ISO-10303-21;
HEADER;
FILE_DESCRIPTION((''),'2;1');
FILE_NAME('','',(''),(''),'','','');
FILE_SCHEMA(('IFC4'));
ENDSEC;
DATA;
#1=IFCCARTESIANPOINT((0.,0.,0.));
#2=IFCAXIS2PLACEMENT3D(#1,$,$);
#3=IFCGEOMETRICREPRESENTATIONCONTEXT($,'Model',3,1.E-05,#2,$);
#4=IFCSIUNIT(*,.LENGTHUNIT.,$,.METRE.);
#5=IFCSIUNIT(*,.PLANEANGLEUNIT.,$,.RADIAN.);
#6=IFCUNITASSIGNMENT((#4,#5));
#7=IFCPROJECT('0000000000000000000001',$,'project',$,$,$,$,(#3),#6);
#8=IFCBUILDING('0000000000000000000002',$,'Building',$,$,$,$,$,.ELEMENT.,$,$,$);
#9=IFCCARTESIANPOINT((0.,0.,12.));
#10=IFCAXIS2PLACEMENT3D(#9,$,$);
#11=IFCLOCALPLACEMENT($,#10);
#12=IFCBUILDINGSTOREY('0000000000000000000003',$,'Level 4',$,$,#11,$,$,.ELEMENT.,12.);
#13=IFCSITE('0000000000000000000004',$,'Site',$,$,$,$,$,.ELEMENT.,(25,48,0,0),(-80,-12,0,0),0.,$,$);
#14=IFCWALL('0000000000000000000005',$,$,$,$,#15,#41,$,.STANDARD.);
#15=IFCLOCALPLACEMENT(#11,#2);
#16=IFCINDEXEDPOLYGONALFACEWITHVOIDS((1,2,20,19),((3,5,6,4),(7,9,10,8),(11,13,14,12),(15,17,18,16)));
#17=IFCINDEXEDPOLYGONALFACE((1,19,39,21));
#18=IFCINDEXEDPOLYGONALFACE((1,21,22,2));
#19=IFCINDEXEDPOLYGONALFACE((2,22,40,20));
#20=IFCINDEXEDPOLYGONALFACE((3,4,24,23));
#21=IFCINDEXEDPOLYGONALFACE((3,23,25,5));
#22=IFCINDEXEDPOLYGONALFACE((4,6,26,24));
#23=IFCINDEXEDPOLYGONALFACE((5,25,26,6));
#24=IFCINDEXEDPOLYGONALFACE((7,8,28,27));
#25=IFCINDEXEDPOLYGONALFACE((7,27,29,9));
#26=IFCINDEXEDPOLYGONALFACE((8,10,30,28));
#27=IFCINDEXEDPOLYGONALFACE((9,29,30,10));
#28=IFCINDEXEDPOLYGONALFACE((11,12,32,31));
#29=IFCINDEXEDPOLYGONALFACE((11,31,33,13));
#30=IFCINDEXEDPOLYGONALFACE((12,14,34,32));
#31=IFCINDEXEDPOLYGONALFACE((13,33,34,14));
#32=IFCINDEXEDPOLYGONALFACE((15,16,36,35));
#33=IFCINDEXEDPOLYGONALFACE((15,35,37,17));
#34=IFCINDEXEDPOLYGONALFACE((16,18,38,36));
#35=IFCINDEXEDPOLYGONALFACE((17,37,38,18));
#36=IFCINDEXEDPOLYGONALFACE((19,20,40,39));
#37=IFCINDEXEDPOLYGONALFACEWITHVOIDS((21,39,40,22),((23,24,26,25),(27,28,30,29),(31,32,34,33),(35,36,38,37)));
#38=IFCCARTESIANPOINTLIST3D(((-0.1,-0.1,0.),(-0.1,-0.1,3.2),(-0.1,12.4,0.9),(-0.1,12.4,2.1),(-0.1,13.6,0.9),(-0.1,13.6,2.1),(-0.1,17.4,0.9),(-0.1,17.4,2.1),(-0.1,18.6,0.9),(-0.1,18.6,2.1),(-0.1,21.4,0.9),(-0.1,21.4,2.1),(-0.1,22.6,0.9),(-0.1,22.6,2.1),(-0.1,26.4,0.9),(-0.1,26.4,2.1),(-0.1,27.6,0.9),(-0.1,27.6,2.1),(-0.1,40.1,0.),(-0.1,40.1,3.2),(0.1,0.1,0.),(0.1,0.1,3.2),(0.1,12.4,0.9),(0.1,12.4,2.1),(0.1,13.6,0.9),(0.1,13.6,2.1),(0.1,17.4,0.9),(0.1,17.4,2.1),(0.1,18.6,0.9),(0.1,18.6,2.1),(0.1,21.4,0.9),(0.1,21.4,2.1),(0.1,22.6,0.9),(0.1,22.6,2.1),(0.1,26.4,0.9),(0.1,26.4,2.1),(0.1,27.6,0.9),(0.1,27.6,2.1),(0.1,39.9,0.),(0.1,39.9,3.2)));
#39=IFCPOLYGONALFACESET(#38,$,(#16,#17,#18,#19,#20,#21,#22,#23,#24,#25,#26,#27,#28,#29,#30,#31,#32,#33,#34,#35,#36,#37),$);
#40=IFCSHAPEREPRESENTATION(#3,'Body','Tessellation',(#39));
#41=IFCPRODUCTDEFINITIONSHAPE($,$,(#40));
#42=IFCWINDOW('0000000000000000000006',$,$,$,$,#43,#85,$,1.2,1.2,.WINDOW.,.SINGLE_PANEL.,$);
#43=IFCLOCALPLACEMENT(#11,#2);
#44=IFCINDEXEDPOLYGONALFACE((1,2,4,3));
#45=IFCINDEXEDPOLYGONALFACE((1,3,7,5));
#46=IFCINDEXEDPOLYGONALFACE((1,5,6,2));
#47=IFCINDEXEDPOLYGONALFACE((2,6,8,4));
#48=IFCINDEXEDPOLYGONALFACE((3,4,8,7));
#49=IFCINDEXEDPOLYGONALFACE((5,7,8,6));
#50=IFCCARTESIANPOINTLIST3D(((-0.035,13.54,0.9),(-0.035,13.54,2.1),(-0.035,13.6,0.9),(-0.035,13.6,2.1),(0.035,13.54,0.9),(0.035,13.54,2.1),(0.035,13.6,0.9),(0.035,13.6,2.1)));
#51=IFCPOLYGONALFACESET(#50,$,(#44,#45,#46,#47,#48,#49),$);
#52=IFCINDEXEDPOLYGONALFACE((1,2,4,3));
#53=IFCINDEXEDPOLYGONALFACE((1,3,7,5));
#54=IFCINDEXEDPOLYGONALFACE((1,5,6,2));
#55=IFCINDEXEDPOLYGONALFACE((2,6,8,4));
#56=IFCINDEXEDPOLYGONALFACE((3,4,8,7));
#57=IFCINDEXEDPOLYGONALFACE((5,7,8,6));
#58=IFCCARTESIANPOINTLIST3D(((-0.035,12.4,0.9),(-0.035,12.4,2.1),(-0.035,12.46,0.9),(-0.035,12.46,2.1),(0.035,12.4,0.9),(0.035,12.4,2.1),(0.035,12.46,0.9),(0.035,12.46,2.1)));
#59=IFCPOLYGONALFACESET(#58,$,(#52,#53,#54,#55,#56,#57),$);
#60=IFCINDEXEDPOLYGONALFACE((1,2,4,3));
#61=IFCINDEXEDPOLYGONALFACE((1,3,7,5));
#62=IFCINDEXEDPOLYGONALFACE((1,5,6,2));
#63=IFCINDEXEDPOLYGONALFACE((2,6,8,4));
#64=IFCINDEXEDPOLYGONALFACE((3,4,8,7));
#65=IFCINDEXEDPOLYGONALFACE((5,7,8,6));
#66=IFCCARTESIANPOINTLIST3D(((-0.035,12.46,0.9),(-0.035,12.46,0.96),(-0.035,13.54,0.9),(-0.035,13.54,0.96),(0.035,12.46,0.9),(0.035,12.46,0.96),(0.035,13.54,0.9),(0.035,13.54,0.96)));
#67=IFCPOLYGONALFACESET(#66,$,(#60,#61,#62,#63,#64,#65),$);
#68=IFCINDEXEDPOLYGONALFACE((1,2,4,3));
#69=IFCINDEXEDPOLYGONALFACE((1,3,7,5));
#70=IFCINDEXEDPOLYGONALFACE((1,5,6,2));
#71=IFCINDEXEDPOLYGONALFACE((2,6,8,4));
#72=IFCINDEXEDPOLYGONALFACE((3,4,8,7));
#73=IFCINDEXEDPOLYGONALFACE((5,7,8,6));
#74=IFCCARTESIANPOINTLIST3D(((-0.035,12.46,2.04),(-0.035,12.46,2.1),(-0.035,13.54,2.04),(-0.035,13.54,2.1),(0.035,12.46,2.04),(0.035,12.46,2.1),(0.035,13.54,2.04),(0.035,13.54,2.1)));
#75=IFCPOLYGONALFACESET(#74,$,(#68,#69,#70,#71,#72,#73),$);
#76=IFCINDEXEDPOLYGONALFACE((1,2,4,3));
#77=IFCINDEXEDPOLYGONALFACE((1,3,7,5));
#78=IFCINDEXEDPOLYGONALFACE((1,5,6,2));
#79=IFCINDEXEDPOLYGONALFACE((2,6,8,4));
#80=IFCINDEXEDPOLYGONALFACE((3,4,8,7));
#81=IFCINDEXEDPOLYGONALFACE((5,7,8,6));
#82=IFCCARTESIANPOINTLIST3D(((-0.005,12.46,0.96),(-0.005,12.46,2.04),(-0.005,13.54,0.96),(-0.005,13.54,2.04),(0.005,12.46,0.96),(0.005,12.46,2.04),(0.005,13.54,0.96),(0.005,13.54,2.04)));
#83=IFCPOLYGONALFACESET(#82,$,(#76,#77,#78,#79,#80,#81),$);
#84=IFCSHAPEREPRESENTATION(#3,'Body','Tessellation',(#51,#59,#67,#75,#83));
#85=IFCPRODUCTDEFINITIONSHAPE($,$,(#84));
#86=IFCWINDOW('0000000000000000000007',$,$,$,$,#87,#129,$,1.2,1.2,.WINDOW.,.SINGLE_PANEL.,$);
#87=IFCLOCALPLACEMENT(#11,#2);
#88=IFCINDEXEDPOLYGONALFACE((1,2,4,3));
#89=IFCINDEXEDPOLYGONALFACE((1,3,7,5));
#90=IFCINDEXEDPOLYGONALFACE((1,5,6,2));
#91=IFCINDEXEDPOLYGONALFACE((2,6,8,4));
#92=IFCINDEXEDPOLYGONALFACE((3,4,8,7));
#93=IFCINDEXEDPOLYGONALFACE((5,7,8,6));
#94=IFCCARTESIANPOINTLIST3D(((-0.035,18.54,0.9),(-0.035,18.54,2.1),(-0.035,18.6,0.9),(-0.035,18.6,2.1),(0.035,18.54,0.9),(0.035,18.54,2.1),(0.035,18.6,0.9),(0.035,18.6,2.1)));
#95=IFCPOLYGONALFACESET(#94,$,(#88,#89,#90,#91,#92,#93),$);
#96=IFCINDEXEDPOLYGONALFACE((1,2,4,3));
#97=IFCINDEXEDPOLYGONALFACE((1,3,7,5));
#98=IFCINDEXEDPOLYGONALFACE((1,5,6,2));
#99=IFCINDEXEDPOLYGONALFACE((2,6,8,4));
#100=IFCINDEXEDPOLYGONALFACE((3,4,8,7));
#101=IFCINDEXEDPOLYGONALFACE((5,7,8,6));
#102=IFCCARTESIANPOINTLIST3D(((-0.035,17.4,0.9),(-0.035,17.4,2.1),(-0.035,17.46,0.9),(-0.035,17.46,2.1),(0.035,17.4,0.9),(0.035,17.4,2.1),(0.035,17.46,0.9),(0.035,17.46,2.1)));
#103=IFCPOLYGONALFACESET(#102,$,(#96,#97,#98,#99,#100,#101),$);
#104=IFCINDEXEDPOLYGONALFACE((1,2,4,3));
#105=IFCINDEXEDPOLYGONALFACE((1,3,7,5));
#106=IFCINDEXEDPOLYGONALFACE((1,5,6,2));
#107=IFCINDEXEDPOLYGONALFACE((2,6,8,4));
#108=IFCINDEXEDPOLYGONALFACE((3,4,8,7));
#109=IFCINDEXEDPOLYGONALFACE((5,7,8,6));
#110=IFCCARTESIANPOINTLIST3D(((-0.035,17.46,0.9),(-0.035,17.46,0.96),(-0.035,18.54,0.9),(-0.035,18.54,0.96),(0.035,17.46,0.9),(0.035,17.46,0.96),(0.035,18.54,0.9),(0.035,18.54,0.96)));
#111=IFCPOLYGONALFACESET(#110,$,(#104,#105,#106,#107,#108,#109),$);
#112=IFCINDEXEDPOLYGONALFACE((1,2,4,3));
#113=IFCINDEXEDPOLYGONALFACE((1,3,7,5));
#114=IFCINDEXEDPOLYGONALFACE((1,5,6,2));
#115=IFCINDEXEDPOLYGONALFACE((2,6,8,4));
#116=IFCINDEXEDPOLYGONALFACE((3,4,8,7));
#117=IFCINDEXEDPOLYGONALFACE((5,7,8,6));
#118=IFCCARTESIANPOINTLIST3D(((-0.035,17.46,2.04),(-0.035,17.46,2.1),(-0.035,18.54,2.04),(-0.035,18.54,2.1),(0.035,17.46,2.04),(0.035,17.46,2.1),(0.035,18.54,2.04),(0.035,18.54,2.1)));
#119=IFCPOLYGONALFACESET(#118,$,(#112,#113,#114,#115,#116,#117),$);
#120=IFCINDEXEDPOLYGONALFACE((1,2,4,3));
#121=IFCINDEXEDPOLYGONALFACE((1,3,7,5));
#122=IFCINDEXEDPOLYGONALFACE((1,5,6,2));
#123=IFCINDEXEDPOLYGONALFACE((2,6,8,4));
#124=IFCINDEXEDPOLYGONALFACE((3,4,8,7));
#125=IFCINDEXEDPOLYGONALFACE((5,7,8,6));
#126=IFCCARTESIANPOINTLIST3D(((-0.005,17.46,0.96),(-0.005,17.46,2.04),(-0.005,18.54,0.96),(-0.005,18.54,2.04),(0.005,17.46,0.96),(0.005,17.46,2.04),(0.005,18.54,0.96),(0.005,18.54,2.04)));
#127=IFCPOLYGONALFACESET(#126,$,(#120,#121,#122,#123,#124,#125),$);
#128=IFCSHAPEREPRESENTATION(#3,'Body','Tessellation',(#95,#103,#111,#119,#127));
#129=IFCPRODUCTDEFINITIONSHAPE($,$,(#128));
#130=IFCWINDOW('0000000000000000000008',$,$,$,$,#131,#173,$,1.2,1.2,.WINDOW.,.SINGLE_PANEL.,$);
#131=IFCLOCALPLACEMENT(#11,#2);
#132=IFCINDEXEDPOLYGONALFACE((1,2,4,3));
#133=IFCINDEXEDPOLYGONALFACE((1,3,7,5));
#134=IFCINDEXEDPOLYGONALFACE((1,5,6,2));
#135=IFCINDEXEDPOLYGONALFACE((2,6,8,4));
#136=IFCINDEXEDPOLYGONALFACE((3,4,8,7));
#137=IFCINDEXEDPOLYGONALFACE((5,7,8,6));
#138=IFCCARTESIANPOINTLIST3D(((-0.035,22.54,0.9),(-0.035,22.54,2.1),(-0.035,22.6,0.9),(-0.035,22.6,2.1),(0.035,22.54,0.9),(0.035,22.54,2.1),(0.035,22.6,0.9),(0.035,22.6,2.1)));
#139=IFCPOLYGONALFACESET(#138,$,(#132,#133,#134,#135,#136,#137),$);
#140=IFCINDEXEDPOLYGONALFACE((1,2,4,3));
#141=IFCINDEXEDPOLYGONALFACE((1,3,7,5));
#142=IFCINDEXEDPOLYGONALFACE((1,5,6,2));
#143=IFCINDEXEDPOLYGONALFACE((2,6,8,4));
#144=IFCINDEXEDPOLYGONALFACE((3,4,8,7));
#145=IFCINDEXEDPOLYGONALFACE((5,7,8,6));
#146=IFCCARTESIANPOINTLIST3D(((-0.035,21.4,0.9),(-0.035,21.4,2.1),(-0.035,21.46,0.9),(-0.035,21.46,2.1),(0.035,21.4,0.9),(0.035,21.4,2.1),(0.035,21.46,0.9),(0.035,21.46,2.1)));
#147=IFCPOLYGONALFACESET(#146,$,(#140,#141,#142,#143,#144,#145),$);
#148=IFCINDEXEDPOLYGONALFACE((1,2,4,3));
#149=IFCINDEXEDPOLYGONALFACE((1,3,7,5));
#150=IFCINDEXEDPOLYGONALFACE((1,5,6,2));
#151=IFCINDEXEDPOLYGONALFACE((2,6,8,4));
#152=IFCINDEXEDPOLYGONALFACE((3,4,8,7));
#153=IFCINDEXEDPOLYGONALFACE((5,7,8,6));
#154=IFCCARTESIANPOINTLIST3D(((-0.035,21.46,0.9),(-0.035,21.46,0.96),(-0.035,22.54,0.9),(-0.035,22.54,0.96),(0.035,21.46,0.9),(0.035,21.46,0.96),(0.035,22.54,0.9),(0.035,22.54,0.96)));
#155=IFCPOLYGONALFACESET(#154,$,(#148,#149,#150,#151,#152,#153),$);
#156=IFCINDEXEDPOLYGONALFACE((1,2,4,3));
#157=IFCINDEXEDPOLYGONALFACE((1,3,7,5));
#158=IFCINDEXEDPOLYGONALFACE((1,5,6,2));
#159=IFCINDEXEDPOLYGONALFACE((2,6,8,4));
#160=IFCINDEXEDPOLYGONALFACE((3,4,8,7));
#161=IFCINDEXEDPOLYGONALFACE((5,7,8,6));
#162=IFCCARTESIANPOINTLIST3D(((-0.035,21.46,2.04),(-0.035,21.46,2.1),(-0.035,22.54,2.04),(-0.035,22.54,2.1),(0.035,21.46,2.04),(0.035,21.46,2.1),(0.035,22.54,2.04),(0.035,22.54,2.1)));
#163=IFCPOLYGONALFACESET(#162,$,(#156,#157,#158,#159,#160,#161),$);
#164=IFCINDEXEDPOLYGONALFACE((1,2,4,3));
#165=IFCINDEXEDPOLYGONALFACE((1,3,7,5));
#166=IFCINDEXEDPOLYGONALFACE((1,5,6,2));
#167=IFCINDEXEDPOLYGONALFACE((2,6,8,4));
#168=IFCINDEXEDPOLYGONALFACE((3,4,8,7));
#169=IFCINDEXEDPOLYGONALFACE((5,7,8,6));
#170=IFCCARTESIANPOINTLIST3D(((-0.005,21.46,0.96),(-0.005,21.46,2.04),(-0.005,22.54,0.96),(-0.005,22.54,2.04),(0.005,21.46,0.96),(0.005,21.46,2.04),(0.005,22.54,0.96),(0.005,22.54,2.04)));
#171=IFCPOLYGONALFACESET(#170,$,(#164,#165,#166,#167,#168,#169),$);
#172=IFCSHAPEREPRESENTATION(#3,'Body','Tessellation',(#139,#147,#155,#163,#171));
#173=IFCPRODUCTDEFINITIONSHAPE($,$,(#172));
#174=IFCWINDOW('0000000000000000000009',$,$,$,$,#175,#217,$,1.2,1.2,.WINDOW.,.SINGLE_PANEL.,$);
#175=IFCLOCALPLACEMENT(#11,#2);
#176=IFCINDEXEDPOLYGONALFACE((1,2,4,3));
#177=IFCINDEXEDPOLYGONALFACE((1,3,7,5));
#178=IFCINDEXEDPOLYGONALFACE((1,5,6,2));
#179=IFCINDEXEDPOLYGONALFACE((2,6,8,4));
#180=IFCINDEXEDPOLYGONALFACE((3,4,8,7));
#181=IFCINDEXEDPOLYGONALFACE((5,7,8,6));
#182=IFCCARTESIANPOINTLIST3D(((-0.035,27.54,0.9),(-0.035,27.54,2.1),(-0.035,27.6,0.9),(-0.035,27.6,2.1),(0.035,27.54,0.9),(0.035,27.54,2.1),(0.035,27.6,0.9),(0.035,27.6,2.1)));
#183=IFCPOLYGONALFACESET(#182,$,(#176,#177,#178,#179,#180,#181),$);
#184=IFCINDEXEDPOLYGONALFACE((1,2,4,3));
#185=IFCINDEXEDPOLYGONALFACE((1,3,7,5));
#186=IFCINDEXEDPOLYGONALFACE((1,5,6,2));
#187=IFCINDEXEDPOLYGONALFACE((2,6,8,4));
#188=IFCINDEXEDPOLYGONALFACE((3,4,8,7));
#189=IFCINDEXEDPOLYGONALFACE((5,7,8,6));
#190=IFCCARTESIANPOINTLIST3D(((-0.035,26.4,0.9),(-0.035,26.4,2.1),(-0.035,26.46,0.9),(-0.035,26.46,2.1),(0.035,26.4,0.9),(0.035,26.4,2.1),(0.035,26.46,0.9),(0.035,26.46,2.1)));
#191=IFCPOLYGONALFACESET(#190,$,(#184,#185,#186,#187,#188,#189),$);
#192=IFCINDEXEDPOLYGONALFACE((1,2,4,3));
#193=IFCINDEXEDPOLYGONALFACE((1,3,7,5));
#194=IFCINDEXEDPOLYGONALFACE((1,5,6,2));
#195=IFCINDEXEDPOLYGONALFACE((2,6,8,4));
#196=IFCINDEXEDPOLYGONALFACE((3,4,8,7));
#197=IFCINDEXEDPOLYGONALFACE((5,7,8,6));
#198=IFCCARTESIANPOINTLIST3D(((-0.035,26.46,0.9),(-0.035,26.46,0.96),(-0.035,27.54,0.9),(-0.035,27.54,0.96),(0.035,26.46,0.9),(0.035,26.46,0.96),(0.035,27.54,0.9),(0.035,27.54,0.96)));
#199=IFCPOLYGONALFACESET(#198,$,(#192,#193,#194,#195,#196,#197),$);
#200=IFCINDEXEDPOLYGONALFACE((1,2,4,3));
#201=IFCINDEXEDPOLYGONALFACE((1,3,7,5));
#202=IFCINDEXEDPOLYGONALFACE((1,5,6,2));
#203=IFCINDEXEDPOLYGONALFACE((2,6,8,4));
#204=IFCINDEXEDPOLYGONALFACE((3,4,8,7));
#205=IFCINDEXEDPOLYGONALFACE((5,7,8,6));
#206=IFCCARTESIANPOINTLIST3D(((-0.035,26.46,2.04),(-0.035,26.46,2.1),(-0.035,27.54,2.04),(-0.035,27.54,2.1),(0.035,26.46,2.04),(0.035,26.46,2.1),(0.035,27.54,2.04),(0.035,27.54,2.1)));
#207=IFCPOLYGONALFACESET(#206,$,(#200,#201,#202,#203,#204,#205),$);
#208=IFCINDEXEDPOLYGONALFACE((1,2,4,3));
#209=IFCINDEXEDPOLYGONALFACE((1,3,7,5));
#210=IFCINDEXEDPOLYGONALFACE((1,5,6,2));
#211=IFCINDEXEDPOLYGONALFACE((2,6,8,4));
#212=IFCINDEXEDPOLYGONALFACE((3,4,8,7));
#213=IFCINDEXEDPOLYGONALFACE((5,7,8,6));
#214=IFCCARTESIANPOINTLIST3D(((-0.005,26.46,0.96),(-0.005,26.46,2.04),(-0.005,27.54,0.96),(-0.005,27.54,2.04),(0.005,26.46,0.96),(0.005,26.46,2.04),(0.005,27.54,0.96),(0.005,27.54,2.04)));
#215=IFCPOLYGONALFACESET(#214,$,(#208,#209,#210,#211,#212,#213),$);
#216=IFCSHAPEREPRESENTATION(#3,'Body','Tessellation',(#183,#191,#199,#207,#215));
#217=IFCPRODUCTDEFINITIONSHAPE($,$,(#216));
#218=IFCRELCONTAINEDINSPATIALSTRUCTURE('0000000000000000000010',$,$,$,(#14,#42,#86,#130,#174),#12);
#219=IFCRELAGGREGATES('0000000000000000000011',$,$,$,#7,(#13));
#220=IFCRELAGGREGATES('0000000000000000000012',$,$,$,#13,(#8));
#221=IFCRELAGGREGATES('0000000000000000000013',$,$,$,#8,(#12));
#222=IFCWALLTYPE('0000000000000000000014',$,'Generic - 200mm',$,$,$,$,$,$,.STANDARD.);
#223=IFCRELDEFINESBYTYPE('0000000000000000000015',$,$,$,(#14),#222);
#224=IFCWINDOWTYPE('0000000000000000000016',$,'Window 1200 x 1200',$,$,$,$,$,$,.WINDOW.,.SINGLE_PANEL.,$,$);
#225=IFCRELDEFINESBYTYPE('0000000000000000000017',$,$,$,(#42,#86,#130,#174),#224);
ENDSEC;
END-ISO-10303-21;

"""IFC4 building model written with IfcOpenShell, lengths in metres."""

from ifc_helpers import new_model, si_unit, frame, frame_2d, origin, origin_with_axes, origin_2d, place, context, project, spatial, polyline, rectangle, outline, extrude, type_object, element, fill, save


model = new_model("IFC4")

# Units and contexts
model_context = context("Model", 3, precision=1e-05, world=origin())
ifc_project = project(units=[si_unit("LENGTHUNIT", "METRE"), si_unit("PLANEANGLEUNIT", "RADIAN")], contexts=[model_context])

# Site, building, storey
site = spatial("IfcSite", under=ifc_project, Name="Site", CompositionType="ELEMENT", RefLatitude=(25, 48, 0, 0), RefLongitude=(-80, -12, 0, 0), RefElevation=0.0)
building = spatial("IfcBuilding", under=site, Name="Building", CompositionType="ELEMENT")
storey_placement = place(None, frame((0.0, 0.0, 12.0)))
storey = spatial("IfcBuildingStorey", under=building, at=storey_placement, Name="Level 4", CompositionType="ELEMENT", Elevation=12.0)

# Wall, openings, windows
wall_type = type_object("IfcWallType", Name="Generic - 200mm", PredefinedType="STANDARD")
wall_1_placement = place(None, frame((0.0, 40.0, 12.0), z_axis=(0.0, 0.0, 1.0), x_axis=(0.0, -1.0, 0.0)))
wall_1 = element("IfcWall", 1, at=wall_1_placement, inside=storey, type_object=wall_type, PredefinedType="STANDARD", context=model_context, shape_type="SweptSolid", body=[
    extrude(outline(polyline([(-0.1, -0.1), (40.1, -0.1), (39.9, 0.1), (0.1, 0.1), (-0.1, -0.1)])), origin(), (0.0, 0.0, 1.0), 3.2),
])
opening_1_placement = place(wall_1_placement, frame((27.0, 0.0, 0.9), z_axis=(0.0, 0.0, 1.0), x_axis=(1.0, 0.0, 0.0)))
opening_1 = element("IfcOpeningElement", 2, at=opening_1_placement, cuts=wall_1, PredefinedType="OPENING", context=model_context, shape_type="SweptSolid", body=[
    extrude(rectangle(XDim=1.2, YDim=0.202, at=origin_2d()), origin(), (0.0, 0.0, 1.0), 1.2),
])
opening_2_placement = place(wall_1_placement, frame((22.0, 0.0, 0.9), z_axis=(0.0, 0.0, 1.0), x_axis=(1.0, 0.0, 0.0)))
opening_2 = element("IfcOpeningElement", 3, at=opening_2_placement, cuts=wall_1, PredefinedType="OPENING", context=model_context, shape_type="SweptSolid", body=[
    extrude(rectangle(XDim=1.2, YDim=0.202, at=origin_2d()), origin(), (0.0, 0.0, 1.0), 1.2),
])
opening_3_placement = place(wall_1_placement, frame((18.0, 0.0, 0.9), z_axis=(0.0, 0.0, 1.0), x_axis=(1.0, 0.0, 0.0)))
opening_3 = element("IfcOpeningElement", 4, at=opening_3_placement, cuts=wall_1, PredefinedType="OPENING", context=model_context, shape_type="SweptSolid", body=[
    extrude(rectangle(XDim=1.2, YDim=0.202, at=origin_2d()), origin(), (0.0, 0.0, 1.0), 1.2),
])
opening_4_placement = place(wall_1_placement, frame((13.0, 0.0, 0.9), z_axis=(0.0, 0.0, 1.0), x_axis=(1.0, 0.0, 0.0)))
opening_4 = element("IfcOpeningElement", 5, at=opening_4_placement, cuts=wall_1, PredefinedType="OPENING", context=model_context, shape_type="SweptSolid", body=[
    extrude(rectangle(XDim=1.2, YDim=0.202, at=origin_2d()), origin(), (0.0, 0.0, 1.0), 1.2),
])
window_type = type_object("IfcWindowType", Name="Window 1200 x 1200", PartitioningType="SINGLE_PANEL", PredefinedType="WINDOW")
window_1_placement = place(opening_1_placement, origin_with_axes())
window_1 = element("IfcWindow", 6, at=window_1_placement, inside=storey, type_object=window_type, OverallHeight=1.2, OverallWidth=1.2, PartitioningType="SINGLE_PANEL", PredefinedType="WINDOW", context=model_context, shape_type="SweptSolid", body=[
    extrude(rectangle(XDim=0.06, YDim=0.07, at=frame_2d((-0.57, 0.0))), origin(), (0.0, 0.0, 1.0), 1.2),
    extrude(rectangle(XDim=0.06, YDim=0.07, at=frame_2d((0.57, 0.0))), origin(), (0.0, 0.0, 1.0), 1.2),
    extrude(rectangle(XDim=1.08, YDim=0.07, at=origin_2d()), origin(), (0.0, 0.0, 1.0), 0.06),
    extrude(rectangle(XDim=1.08, YDim=0.07, at=origin_2d()), frame((0.0, 0.0, 1.14)), (0.0, 0.0, 1.0), 0.06),
    extrude(rectangle(XDim=1.08, YDim=0.01, at=origin_2d()), frame((0.0, 0.0, 0.06)), (0.0, 0.0, 1.0), 1.08),
])
fill(opening_1, window_1)
window_2_placement = place(opening_2_placement, origin_with_axes())
window_2 = element("IfcWindow", 7, at=window_2_placement, inside=storey, type_object=window_type, OverallHeight=1.2, OverallWidth=1.2, PartitioningType="SINGLE_PANEL", PredefinedType="WINDOW", context=model_context, shape_type="SweptSolid", body=[
    extrude(rectangle(XDim=0.06, YDim=0.07, at=frame_2d((-0.57, 0.0))), origin(), (0.0, 0.0, 1.0), 1.2),
    extrude(rectangle(XDim=0.06, YDim=0.07, at=frame_2d((0.57, 0.0))), origin(), (0.0, 0.0, 1.0), 1.2),
    extrude(rectangle(XDim=1.08, YDim=0.07, at=origin_2d()), origin(), (0.0, 0.0, 1.0), 0.06),
    extrude(rectangle(XDim=1.08, YDim=0.07, at=origin_2d()), frame((0.0, 0.0, 1.14)), (0.0, 0.0, 1.0), 0.06),
    extrude(rectangle(XDim=1.08, YDim=0.01, at=origin_2d()), frame((0.0, 0.0, 0.06)), (0.0, 0.0, 1.0), 1.08),
])
fill(opening_2, window_2)
window_3_placement = place(opening_3_placement, origin_with_axes())
window_3 = element("IfcWindow", 8, at=window_3_placement, inside=storey, type_object=window_type, OverallHeight=1.2, OverallWidth=1.2, PartitioningType="SINGLE_PANEL", PredefinedType="WINDOW", context=model_context, shape_type="SweptSolid", body=[
    extrude(rectangle(XDim=0.06, YDim=0.07, at=frame_2d((-0.57, 0.0))), origin(), (0.0, 0.0, 1.0), 1.2),
    extrude(rectangle(XDim=0.06, YDim=0.07, at=frame_2d((0.57, 0.0))), origin(), (0.0, 0.0, 1.0), 1.2),
    extrude(rectangle(XDim=1.08, YDim=0.07, at=origin_2d()), origin(), (0.0, 0.0, 1.0), 0.06),
    extrude(rectangle(XDim=1.08, YDim=0.07, at=origin_2d()), frame((0.0, 0.0, 1.14)), (0.0, 0.0, 1.0), 0.06),
    extrude(rectangle(XDim=1.08, YDim=0.01, at=origin_2d()), frame((0.0, 0.0, 0.06)), (0.0, 0.0, 1.0), 1.08),
])
fill(opening_3, window_3)
window_4_placement = place(opening_4_placement, origin_with_axes())
window_4 = element("IfcWindow", 9, at=window_4_placement, inside=storey, type_object=window_type, OverallHeight=1.2, OverallWidth=1.2, PartitioningType="SINGLE_PANEL", PredefinedType="WINDOW", context=model_context, shape_type="SweptSolid", body=[
    extrude(rectangle(XDim=0.06, YDim=0.07, at=frame_2d((-0.57, 0.0))), origin(), (0.0, 0.0, 1.0), 1.2),
    extrude(rectangle(XDim=0.06, YDim=0.07, at=frame_2d((0.57, 0.0))), origin(), (0.0, 0.0, 1.0), 1.2),
    extrude(rectangle(XDim=1.08, YDim=0.07, at=origin_2d()), origin(), (0.0, 0.0, 1.0), 0.06),
    extrude(rectangle(XDim=1.08, YDim=0.07, at=origin_2d()), frame((0.0, 0.0, 1.14)), (0.0, 0.0, 1.0), 0.06),
    extrude(rectangle(XDim=1.08, YDim=0.01, at=origin_2d()), frame((0.0, 0.0, 0.06)), (0.0, 0.0, 1.0), 1.08),
])
fill(opening_4, window_4)

save(model, "model.ifc")
